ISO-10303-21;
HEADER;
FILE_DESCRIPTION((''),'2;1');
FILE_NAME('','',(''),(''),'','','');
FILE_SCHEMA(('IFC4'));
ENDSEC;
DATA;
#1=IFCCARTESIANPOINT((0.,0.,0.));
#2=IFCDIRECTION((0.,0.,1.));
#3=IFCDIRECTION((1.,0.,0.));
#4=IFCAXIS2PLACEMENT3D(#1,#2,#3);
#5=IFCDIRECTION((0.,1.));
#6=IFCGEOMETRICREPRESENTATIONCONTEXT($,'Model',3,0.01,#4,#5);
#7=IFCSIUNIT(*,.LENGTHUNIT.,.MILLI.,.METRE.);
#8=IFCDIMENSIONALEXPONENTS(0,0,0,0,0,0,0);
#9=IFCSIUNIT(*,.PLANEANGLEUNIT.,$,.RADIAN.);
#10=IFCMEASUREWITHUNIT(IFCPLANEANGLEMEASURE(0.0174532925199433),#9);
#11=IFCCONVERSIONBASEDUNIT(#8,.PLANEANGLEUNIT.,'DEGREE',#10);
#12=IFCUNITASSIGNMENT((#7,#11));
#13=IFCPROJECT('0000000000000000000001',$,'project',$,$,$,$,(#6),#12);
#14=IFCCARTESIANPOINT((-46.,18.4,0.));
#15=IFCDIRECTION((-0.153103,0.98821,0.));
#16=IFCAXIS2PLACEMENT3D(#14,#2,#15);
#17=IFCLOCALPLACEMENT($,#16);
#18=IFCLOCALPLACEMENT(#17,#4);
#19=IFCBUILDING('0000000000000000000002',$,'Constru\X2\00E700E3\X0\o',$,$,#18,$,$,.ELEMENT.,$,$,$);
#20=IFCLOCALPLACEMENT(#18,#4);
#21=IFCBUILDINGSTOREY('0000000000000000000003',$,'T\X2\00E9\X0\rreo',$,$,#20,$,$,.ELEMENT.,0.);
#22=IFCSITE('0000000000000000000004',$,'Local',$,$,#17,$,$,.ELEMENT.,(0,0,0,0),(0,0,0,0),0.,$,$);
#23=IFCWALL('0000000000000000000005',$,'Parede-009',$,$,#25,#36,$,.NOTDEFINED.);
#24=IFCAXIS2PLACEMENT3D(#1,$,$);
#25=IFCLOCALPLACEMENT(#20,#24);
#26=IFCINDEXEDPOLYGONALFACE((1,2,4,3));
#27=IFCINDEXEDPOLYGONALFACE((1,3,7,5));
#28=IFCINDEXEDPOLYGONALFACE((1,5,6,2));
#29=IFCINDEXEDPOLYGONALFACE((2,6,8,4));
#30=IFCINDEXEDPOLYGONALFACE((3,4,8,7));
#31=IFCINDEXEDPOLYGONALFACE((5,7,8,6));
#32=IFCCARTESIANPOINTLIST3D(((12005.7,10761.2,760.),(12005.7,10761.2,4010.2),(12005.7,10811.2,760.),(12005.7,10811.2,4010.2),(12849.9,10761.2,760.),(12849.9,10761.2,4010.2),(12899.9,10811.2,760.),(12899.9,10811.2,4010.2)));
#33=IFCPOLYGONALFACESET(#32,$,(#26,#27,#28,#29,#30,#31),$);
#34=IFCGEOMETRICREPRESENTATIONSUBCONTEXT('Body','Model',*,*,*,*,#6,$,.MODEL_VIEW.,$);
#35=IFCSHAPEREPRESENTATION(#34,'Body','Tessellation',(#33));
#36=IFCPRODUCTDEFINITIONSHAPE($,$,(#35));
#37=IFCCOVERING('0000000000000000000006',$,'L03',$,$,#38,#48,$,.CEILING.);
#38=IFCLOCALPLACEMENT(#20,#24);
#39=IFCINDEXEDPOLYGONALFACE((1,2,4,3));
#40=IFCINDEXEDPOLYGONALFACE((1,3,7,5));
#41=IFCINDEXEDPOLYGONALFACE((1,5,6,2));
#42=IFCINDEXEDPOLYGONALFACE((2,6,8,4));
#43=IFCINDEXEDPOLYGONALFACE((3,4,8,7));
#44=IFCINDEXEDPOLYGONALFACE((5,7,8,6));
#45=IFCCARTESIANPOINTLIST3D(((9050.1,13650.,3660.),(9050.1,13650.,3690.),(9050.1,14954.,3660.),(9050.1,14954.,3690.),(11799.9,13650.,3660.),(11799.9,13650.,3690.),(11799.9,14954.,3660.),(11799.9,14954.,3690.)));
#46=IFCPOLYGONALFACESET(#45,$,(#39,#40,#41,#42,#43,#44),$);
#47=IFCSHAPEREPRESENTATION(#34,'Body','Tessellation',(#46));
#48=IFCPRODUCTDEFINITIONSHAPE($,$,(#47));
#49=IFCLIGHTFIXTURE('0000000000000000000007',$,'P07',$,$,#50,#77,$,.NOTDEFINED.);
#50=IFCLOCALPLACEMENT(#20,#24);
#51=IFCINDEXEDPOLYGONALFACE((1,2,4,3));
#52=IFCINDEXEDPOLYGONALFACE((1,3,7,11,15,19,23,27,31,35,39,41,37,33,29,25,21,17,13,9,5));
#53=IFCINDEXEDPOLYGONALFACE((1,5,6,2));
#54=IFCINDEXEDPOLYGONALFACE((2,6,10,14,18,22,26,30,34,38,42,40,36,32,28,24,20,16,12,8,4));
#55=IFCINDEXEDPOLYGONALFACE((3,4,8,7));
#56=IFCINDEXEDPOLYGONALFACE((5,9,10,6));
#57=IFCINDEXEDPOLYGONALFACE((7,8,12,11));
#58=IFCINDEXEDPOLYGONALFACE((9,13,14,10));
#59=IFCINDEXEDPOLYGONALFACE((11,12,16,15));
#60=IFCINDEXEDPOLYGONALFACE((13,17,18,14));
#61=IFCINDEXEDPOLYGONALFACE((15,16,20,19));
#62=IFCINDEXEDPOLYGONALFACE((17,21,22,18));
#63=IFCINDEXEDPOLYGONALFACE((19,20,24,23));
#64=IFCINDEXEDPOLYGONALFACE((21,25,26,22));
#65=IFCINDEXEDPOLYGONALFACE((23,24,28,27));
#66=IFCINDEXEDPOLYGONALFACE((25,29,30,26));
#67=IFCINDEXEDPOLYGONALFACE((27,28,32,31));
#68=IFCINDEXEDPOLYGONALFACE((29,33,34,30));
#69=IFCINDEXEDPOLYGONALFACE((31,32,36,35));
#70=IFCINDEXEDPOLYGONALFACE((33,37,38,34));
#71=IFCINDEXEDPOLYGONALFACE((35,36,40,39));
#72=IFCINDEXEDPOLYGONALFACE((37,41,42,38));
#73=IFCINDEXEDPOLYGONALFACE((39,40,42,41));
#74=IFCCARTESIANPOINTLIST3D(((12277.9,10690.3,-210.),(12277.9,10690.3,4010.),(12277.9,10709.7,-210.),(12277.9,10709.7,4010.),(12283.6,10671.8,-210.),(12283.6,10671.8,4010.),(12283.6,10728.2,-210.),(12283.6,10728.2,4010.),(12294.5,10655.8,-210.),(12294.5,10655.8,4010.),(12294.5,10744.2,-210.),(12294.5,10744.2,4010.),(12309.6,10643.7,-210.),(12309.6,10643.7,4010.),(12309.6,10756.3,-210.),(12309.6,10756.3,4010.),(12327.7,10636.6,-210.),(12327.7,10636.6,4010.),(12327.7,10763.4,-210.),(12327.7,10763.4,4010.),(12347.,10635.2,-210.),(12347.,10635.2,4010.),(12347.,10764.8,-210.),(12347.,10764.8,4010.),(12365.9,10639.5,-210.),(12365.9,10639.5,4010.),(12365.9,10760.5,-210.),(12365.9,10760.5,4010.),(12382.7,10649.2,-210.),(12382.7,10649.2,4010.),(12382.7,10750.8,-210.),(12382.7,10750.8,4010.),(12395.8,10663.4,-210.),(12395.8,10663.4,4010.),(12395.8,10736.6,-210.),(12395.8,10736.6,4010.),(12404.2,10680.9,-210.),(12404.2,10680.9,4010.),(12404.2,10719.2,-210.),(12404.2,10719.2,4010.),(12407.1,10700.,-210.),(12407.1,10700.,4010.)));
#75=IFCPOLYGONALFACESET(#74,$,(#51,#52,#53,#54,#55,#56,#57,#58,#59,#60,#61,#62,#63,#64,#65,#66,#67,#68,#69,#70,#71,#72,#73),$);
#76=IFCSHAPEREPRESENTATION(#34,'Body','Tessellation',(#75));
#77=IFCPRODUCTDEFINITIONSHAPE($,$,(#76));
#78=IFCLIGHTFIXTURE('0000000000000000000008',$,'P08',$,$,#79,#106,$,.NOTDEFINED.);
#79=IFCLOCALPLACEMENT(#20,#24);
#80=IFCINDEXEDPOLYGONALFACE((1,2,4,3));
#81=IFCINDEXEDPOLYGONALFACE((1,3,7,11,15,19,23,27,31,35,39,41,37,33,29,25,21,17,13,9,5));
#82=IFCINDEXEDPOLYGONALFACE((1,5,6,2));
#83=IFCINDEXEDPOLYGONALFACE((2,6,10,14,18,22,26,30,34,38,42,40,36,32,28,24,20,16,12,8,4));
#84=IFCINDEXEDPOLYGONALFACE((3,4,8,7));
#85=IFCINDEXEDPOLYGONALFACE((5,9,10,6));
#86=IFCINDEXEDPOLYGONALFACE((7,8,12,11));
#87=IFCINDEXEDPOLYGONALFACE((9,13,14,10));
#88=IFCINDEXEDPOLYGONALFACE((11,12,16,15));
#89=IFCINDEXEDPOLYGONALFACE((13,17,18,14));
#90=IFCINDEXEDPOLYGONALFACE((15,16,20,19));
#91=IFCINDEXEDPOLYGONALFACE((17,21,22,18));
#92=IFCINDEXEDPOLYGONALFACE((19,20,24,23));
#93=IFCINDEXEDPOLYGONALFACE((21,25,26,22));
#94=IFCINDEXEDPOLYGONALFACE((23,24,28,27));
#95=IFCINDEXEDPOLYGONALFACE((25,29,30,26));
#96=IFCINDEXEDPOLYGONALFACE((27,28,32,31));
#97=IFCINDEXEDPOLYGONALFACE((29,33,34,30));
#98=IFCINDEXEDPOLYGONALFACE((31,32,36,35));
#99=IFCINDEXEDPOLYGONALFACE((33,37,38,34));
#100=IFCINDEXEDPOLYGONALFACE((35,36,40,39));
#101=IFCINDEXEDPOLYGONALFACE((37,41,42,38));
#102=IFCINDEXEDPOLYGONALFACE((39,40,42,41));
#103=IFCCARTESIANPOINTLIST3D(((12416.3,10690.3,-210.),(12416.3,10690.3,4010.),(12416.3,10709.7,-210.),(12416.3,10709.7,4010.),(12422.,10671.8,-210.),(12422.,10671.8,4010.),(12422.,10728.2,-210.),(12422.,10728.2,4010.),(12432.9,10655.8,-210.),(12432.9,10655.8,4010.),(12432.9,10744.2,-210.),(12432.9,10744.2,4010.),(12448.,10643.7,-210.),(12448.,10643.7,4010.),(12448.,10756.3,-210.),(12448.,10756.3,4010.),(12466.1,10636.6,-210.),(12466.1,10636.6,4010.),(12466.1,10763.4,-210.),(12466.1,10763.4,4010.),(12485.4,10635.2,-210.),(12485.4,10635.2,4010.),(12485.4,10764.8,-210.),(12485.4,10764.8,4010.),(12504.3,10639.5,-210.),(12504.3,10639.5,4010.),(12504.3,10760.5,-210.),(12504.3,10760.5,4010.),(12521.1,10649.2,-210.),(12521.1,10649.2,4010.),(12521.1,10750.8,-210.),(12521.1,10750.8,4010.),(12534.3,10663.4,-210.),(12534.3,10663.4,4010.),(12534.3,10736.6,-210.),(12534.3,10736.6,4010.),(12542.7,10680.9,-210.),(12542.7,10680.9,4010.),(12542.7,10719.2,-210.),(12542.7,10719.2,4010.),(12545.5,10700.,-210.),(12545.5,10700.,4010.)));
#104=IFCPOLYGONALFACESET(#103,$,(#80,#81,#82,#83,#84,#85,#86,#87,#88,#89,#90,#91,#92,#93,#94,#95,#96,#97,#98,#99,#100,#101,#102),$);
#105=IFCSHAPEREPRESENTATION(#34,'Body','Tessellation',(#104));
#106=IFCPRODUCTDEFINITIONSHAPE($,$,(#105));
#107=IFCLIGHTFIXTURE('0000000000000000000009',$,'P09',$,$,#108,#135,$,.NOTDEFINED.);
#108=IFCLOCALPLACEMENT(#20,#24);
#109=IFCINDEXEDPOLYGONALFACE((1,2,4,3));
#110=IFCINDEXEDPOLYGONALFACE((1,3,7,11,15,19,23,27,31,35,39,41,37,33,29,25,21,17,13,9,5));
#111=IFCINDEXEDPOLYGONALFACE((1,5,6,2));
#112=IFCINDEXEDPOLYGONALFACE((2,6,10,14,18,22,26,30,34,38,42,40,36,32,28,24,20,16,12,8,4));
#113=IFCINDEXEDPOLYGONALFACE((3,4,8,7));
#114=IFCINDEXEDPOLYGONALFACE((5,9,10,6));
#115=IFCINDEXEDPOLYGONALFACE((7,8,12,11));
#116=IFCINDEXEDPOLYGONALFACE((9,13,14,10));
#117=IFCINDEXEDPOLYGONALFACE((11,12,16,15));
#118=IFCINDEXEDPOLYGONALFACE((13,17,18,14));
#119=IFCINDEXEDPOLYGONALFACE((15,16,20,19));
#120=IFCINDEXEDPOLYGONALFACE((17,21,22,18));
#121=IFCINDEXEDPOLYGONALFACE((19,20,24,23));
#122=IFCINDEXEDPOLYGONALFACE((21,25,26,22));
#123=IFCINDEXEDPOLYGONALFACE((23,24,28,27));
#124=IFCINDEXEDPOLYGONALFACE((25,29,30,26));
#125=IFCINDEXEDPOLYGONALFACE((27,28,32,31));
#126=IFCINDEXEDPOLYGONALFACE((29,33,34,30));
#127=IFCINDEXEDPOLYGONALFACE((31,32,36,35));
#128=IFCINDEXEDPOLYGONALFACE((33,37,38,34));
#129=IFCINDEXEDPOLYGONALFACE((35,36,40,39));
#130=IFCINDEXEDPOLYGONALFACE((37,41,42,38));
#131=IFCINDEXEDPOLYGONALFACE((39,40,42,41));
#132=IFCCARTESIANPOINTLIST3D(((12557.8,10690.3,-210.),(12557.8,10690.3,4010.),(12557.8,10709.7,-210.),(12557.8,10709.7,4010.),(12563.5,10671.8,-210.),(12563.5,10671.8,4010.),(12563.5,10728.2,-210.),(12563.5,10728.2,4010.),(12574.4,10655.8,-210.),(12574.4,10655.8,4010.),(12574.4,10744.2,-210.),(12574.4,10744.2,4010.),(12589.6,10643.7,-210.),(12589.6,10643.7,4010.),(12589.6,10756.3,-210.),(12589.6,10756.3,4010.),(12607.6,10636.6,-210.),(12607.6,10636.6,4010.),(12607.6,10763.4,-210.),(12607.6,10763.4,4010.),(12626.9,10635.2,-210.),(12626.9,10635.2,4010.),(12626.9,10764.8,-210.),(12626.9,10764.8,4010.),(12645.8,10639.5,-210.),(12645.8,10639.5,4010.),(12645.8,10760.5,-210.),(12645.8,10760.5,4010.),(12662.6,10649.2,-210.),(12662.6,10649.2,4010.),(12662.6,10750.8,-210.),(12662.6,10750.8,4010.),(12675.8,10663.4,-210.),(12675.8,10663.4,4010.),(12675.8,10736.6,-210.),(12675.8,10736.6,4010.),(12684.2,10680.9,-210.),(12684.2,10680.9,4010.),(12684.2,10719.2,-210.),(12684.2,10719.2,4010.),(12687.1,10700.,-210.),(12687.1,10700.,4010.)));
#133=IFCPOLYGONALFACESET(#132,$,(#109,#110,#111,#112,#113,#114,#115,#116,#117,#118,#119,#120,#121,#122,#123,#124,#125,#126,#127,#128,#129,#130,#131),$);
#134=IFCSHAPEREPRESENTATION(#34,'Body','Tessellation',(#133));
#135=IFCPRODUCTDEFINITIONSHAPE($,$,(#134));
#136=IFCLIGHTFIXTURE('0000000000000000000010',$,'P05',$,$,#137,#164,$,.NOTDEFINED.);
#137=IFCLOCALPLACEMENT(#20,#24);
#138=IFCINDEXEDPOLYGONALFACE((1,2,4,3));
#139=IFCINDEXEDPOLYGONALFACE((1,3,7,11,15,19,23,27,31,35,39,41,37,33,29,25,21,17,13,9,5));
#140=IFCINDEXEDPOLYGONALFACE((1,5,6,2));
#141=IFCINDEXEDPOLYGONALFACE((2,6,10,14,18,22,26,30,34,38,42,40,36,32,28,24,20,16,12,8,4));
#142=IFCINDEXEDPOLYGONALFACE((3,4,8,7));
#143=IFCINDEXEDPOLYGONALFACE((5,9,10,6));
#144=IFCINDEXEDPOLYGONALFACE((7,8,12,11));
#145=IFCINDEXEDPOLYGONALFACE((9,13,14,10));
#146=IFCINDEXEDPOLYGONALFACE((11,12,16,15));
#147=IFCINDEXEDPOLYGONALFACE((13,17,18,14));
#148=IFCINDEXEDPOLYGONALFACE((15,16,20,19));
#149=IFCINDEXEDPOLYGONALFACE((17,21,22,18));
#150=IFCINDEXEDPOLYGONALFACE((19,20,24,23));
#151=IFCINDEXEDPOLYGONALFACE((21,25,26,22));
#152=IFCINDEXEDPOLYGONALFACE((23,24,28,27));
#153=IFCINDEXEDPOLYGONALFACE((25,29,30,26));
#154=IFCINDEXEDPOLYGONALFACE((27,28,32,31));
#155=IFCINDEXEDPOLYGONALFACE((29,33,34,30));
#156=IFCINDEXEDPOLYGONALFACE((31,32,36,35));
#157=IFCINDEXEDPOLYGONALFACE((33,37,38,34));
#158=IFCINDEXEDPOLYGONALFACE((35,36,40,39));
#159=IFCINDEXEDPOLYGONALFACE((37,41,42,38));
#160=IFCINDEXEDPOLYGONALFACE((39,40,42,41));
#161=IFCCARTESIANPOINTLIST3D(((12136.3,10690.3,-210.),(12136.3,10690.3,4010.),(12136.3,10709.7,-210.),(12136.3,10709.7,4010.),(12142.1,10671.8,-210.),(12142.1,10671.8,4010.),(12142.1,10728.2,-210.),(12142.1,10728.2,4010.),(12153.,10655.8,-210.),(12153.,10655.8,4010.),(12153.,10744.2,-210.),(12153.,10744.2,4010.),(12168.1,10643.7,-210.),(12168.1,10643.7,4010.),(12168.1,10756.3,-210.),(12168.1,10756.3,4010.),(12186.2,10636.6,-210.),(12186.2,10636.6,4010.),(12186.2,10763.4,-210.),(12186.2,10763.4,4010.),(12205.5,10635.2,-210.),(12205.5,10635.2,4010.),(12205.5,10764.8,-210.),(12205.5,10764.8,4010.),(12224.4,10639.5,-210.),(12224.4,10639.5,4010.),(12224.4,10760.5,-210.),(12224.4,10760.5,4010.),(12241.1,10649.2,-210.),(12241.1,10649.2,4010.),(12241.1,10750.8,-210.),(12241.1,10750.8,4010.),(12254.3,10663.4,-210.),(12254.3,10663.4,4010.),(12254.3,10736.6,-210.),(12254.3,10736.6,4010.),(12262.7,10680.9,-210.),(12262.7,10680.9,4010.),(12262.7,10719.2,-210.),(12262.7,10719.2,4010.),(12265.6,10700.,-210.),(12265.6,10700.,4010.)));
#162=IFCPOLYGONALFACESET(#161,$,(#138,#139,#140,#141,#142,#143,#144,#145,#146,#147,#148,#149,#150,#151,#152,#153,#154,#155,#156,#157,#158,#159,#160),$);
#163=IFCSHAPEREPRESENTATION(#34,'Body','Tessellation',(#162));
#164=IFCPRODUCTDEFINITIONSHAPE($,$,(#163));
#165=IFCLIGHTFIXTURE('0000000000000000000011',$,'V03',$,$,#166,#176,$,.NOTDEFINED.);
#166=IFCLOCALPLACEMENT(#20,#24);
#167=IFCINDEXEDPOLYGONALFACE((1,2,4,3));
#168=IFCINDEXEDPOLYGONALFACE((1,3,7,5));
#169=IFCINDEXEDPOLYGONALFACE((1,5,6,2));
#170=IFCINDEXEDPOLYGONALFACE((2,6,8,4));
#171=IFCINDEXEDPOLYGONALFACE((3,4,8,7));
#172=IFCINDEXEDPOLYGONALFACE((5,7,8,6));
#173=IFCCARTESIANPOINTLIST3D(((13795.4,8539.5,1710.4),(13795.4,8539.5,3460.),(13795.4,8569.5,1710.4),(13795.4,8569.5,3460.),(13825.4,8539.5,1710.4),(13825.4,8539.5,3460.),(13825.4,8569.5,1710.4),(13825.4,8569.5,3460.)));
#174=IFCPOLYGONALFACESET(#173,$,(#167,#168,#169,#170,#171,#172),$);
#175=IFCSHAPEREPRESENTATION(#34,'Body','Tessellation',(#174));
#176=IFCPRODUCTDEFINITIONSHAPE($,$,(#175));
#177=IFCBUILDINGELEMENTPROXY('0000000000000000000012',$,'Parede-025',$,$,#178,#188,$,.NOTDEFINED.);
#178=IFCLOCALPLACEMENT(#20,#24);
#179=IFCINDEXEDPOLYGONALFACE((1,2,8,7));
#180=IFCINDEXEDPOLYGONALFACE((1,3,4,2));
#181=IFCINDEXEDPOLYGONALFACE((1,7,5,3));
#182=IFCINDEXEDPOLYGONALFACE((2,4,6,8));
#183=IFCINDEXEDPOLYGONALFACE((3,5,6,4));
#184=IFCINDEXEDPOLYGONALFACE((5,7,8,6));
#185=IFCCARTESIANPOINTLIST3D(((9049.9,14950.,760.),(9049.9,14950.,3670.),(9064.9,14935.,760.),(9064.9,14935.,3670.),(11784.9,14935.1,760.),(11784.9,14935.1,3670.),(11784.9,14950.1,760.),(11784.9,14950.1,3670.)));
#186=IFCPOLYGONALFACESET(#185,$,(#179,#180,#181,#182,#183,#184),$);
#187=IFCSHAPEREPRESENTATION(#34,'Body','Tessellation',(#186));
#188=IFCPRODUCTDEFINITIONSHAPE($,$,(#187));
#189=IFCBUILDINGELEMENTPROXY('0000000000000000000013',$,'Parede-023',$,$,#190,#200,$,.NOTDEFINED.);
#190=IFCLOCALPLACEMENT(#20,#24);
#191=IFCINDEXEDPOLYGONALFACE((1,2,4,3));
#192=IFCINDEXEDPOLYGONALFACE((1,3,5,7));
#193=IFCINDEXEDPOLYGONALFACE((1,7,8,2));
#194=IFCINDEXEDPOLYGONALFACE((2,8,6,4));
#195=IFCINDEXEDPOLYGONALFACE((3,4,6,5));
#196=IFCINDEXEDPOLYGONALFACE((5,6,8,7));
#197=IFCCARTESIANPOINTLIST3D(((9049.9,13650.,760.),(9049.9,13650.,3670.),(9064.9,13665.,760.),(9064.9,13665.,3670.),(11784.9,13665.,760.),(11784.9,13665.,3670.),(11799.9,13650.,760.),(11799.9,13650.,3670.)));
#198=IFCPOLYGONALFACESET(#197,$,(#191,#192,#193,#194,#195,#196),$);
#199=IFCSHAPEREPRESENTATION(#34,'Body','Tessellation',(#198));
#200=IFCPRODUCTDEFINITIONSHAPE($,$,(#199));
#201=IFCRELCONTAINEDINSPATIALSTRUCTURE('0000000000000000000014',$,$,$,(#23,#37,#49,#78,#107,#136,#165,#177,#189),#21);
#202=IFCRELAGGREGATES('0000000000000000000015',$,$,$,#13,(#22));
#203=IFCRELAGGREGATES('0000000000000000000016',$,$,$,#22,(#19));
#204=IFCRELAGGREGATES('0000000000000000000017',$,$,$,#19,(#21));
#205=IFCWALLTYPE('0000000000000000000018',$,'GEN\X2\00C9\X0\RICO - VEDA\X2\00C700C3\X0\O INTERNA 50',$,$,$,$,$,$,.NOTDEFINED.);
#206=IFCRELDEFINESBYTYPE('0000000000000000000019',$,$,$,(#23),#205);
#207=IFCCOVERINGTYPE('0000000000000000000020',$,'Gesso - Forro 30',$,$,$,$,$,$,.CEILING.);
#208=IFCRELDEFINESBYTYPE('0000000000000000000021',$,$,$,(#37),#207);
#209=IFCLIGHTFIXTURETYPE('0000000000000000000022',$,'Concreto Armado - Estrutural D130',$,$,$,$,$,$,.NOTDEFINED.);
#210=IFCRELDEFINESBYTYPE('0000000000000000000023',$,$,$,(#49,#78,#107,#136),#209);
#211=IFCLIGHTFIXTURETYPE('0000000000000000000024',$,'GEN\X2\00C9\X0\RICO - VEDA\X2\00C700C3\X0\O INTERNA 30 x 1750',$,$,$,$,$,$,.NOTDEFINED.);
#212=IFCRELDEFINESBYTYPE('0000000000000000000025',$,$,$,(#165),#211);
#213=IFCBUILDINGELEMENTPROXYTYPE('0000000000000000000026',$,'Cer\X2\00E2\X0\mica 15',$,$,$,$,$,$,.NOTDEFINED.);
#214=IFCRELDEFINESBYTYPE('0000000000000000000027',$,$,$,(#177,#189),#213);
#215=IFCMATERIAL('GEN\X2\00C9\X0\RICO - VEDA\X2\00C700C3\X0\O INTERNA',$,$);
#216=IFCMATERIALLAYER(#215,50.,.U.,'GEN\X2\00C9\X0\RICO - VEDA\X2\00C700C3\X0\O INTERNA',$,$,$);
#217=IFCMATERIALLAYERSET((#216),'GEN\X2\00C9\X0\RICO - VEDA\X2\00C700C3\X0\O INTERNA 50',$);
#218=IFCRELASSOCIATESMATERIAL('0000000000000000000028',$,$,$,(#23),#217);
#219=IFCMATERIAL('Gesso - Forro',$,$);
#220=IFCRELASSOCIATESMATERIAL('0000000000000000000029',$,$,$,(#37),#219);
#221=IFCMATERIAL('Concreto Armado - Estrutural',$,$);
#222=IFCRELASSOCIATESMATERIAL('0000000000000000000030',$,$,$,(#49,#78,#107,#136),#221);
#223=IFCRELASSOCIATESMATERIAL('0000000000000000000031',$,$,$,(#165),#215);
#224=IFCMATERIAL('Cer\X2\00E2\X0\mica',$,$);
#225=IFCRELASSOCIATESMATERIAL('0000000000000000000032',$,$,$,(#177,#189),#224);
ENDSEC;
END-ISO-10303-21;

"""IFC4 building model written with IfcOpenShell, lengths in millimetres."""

from ifc_helpers import new_model, entity, si_unit, converted_unit, direction, frame, frame_2d, origin_with_axes, origin_2d_with_axis, place, context, subcontext, project, spatial, line, indexed_curve, rectangle, circle, outline, extrude, material, layer, layer_set, layer_usage, type_object, element, save


model = new_model("IFC4")

# Units and contexts
model_context = context("Model", 3, precision=0.01, world=origin_with_axes(), true_north=direction((0.0, 1.0)))
body_context = subcontext(model_context, "Body", "Model", "MODEL_VIEW")
ifc_project = project(units=[si_unit("LENGTHUNIT", "METRE", prefix="MILLI"), converted_unit("PLANEANGLEUNIT", "DEGREE", entity("IfcPlaneAngleMeasure", 0.0174532925199433), si_unit("PLANEANGLEUNIT", "RADIAN"), dimensions=[0, 0, 0, 0, 0, 0, 0])], contexts=[model_context])

# Site, building, storey
site_placement = place(None, frame((-46.0, 18.4, 0.0), z_axis=(0.0, 0.0, 1.0), x_axis=(-0.153103, 0.98821, 0.0)))
site = spatial("IfcSite", under=ifc_project, at=site_placement, Name="Local", CompositionType="ELEMENT", RefLatitude=(0, 0, 0, 0), RefLongitude=(0, 0, 0, 0), RefElevation=0.0)
building_placement = place(site_placement, origin_with_axes())
building = spatial("IfcBuilding", under=site, at=building_placement, Name="Construção", CompositionType="ELEMENT")
storey_placement = place(building_placement, origin_with_axes())
storey = spatial("IfcBuildingStorey", under=building, at=storey_placement, Name="Térreo", CompositionType="ELEMENT", Elevation=0.0)

# Wall
ifc_material_1 = material(Name="GENÉRICO - VEDAÇÃO INTERNA")
ifc_layer_1 = layer(ifc_material_1, 50.0, ventilated="UNKNOWN", Name="GENÉRICO - VEDAÇÃO INTERNA")
ifc_layer_set_1 = layer_set([ifc_layer_1], Name="GENÉRICO - VEDAÇÃO INTERNA 50")
wall_type_1 = type_object("IfcWallType", Name="GENÉRICO - VEDAÇÃO INTERNA 50", PredefinedType="NOTDEFINED")
ifc_layer_usage_1 = layer_usage(ifc_layer_set_1, "AXIS2", "POSITIVE", 0.0)
wall_1_placement = place(storey_placement, frame((12899.9, 10811.2, 760.0), z_axis=(0.0, 0.0, 1.0), x_axis=(-1.0, -0.000002, 0.0)))
element("IfcWall", 1, at=wall_1_placement, inside=storey, type_object=wall_type_1, material=ifc_layer_usage_1, Name="Parede-009", PredefinedType="NOTDEFINED", context=body_context, shape_type="SweptSolid", body=[
    extrude(outline(indexed_curve([(0.0, 0.0), (894.2, 0.0), (894.2, 50.0), (50.0, 50.0)], segments=[line(1, 2, 3, 4, 1)])), origin_with_axes(), (0.0, 0.0, 1.0), 3250.2),
])

# Covering
ifc_material_2 = material(Name="Gesso - Forro")
covering_type = type_object("IfcCoveringType", Name="Gesso - Forro 30", PredefinedType="CEILING")
covering_placement = place(storey_placement, frame((9050.1, 13650.0, 3690.0), z_axis=(0.0, 0.0, 1.0), x_axis=(1.0, 0.0, 0.0)))
element("IfcCovering", 2, at=covering_placement, inside=storey, type_object=covering_type, material=ifc_material_2, Name="L03", PredefinedType="CEILING", context=body_context, shape_type="SweptSolid", body=[
    extrude(outline(indexed_curve([(0.0, 0.0), (2749.9, 0.0), (2749.9, 1304.0), (0.0, 1304.0)], segments=[line(1, 2, 3, 4, 1)])), frame((0.0, 0.0, -30.0), z_axis=(0.0, 0.0, 1.0), x_axis=(1.0, 0.0, 0.0)), (0.0, 0.0, 1.0), 30.0),
])

# Light fixtures
ifc_material_3 = material(Name="Concreto Armado - Estrutural")
light_fixture_type_1 = type_object("IfcLightFixtureType", Name="Concreto Armado - Estrutural D130", PredefinedType="NOTDEFINED")
for number, where, z_axis, x_axis, name in (
    (3, (12342.1, 10700.0, -210.0), (0.0, 0.0, 1.0), (1.0, 0.0, 0.0), "P07"),
    (4, (12480.5, 10700.0, -210.0), (0.0, 0.0, 1.0), (1.0, 0.0, 0.0), "P08"),
    (5, (12622.1, 10700.0, -210.0), (0.0, 0.0, 1.0), (1.0, 0.0, 0.0), "P09"),
    (6, (12200.6, 10700.0, -210.0), (0.0, 0.0, 1.0), (1.0, 0.0, 0.0), "P05"),
):
    element("IfcLightFixture", number, at=place(storey_placement, frame(where, z_axis=z_axis, x_axis=x_axis)), inside=storey, type_object=light_fixture_type_1, material=ifc_material_3, Name=name, PredefinedType="NOTDEFINED", context=body_context, shape_type="SweptSolid", body=[
        extrude(circle(Radius=65.0, at=origin_2d_with_axis()), origin_with_axes(), (0.0, 0.0, 1.0), 4220.0),
    ])

# Light fixture
light_fixture_type_2 = type_object("IfcLightFixtureType", Name="GENÉRICO - VEDAÇÃO INTERNA 30 x 1750", PredefinedType="NOTDEFINED")
light_fixture_1_placement = place(storey_placement, frame((13795.4, 8569.5, 3460.0), z_axis=(0.0, 0.0, 1.0), x_axis=(0.000002, -1.0, 0.0)))
element("IfcLightFixture", 7, at=light_fixture_1_placement, inside=storey, type_object=light_fixture_type_2, material=ifc_material_1, Name="V03", PredefinedType="NOTDEFINED", context=body_context, shape_type="SweptSolid", body=[
    extrude(rectangle(XDim=1749.6, YDim=30.0, at=frame_2d((-874.8, 15.0), x_axis=(1.0, 0.0))), frame((0.0, 0.0, 0.0), z_axis=(0.0, 1.0, 0.0), x_axis=(0.0, 0.0, 1.0)), (0.0, 0.0, 1.0), 30.0),
])

# Building element proxies
ifc_material_4 = material(Name="Cerâmica")
building_element_proxy_type_1 = type_object("IfcBuildingElementProxyType", Name="Cerâmica 15", PredefinedType="NOTDEFINED")
proxy_1_placement = place(storey_placement, frame((11784.9, 14950.1, 760.0), z_axis=(0.0, 0.0, 1.0), x_axis=(-1.0, -0.000028, 0.0)))
element("IfcBuildingElementProxy", 8, at=proxy_1_placement, inside=storey, type_object=building_element_proxy_type_1, material=ifc_material_4, Name="Parede-025", PredefinedType="NOTDEFINED", context=body_context, shape_type="SweptSolid", body=[
    extrude(outline(indexed_curve([(0.0, 0.0), (2735.0, 0.0), (2720.0, 15.0), (0.0, 15.0)], segments=[line(1, 2, 3, 4, 1)])), origin_with_axes(), (0.0, 0.0, 1.0), 2910.0),
])
proxy_2_placement = place(storey_placement, frame((9049.9, 13650.0, 760.0), z_axis=(0.0, 0.0, 1.0), x_axis=(1.0, 0.000002, 0.0)))
element("IfcBuildingElementProxy", 9, at=proxy_2_placement, inside=storey, type_object=building_element_proxy_type_1, material=ifc_material_4, Name="Parede-023", PredefinedType="NOTDEFINED", context=body_context, shape_type="SweptSolid", body=[
    extrude(outline(indexed_curve([(0.0, 0.0), (2750.0, 0.0), (2735.0, 15.0), (15.0, 15.0)], segments=[line(1, 2, 3, 4, 1)])), origin_with_axes(), (0.0, 0.0, 1.0), 2910.0),
])

save(model, "model.ifc")
